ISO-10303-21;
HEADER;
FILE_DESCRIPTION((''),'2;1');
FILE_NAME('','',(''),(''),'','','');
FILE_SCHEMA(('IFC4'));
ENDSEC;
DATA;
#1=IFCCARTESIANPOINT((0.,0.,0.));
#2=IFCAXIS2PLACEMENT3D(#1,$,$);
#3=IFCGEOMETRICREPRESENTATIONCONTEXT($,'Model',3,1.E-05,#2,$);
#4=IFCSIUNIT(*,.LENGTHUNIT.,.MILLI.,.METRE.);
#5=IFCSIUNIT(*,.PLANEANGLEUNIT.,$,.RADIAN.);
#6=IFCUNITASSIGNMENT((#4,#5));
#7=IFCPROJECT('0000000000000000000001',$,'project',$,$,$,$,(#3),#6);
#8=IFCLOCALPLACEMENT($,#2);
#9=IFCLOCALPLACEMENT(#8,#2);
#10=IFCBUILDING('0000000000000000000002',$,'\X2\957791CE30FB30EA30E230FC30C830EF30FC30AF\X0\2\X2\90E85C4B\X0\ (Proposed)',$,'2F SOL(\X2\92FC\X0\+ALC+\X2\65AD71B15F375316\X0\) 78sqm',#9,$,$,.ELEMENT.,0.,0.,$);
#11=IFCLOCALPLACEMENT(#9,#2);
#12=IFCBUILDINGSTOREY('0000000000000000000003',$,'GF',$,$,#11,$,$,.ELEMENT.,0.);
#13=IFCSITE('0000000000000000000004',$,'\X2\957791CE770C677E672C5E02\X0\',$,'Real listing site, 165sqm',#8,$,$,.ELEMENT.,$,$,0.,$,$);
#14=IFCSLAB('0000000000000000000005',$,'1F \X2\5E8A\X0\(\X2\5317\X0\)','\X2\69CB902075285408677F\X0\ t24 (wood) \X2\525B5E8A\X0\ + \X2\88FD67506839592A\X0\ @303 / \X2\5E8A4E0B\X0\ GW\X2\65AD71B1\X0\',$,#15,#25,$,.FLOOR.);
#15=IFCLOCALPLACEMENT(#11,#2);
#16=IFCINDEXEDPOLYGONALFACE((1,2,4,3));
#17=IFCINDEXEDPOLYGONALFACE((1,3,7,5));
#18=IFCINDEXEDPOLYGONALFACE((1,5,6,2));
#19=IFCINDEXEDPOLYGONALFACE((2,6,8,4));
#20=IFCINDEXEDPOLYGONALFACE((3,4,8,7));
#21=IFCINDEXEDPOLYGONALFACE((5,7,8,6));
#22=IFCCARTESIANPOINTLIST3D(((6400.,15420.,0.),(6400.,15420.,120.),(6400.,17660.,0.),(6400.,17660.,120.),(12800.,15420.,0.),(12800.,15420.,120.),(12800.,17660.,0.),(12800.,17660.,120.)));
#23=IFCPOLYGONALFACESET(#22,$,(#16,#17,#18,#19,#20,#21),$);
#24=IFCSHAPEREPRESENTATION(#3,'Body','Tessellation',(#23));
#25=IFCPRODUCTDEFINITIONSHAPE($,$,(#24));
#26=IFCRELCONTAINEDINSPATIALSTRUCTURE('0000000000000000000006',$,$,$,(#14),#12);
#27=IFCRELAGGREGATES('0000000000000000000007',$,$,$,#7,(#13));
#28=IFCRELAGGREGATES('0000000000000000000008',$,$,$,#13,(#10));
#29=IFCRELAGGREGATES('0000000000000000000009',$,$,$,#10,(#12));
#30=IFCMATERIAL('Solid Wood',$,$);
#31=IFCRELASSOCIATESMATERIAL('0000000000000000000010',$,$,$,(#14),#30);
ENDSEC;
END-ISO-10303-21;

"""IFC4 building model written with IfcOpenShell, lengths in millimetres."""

from ifc_helpers import new_model, si_unit, frame, frame_2d, origin, place, context, project, spatial, rectangle, extrude, material, element, save


model = new_model("IFC4")

# Units and contexts
model_context = context("Model", 3, precision=1e-05, world=origin())
ifc_project = project(units=[si_unit("LENGTHUNIT", "METRE", prefix="MILLI"), si_unit("PLANEANGLEUNIT", "RADIAN")], contexts=[model_context])

# Site, building, storey
site_placement = place(None, origin())
site = spatial("IfcSite", under=ifc_project, at=site_placement, Name="長野県松本市", ObjectType="Real listing site, 165sqm", CompositionType="ELEMENT", RefElevation=0.0)
building_placement = place(site_placement, origin())
building = spatial("IfcBuilding", under=site, at=building_placement, Name="長野・リモートワーク2部屋 (Proposed)", ObjectType="2F SOL(鋼+ALC+断熱強化) 78sqm", CompositionType="ELEMENT", ElevationOfRefHeight=0.0, ElevationOfTerrain=0.0)
storey_placement = place(building_placement, origin())
storey = spatial("IfcBuildingStorey", under=building, at=storey_placement, Name="GF", CompositionType="ELEMENT", Elevation=0.0)

# Shared definitions
ifc_material_1 = material(Name="Solid Wood")

# Slab
slab_placement = place(storey_placement, frame((3200.0, 7710.0, 0.0)))
element("IfcSlab", 1, at=slab_placement, inside=storey, material=ifc_material_1, Name="1F 床(北)", Description="構造用合板 t24 (wood) 剛床 + 製材根太 @303 / 床下 GW断熱", PredefinedType="FLOOR", context=model_context, shape_type="SweptSolid", body=[
    extrude(rectangle(XDim=6400.0, YDim=2240.0, at=frame_2d((3200.0, 1120.0))), frame((3200.0, 7710.0, 0.0)), (0.0, 0.0, 1.0), 120.0),
])

save(model, "model.ifc")
